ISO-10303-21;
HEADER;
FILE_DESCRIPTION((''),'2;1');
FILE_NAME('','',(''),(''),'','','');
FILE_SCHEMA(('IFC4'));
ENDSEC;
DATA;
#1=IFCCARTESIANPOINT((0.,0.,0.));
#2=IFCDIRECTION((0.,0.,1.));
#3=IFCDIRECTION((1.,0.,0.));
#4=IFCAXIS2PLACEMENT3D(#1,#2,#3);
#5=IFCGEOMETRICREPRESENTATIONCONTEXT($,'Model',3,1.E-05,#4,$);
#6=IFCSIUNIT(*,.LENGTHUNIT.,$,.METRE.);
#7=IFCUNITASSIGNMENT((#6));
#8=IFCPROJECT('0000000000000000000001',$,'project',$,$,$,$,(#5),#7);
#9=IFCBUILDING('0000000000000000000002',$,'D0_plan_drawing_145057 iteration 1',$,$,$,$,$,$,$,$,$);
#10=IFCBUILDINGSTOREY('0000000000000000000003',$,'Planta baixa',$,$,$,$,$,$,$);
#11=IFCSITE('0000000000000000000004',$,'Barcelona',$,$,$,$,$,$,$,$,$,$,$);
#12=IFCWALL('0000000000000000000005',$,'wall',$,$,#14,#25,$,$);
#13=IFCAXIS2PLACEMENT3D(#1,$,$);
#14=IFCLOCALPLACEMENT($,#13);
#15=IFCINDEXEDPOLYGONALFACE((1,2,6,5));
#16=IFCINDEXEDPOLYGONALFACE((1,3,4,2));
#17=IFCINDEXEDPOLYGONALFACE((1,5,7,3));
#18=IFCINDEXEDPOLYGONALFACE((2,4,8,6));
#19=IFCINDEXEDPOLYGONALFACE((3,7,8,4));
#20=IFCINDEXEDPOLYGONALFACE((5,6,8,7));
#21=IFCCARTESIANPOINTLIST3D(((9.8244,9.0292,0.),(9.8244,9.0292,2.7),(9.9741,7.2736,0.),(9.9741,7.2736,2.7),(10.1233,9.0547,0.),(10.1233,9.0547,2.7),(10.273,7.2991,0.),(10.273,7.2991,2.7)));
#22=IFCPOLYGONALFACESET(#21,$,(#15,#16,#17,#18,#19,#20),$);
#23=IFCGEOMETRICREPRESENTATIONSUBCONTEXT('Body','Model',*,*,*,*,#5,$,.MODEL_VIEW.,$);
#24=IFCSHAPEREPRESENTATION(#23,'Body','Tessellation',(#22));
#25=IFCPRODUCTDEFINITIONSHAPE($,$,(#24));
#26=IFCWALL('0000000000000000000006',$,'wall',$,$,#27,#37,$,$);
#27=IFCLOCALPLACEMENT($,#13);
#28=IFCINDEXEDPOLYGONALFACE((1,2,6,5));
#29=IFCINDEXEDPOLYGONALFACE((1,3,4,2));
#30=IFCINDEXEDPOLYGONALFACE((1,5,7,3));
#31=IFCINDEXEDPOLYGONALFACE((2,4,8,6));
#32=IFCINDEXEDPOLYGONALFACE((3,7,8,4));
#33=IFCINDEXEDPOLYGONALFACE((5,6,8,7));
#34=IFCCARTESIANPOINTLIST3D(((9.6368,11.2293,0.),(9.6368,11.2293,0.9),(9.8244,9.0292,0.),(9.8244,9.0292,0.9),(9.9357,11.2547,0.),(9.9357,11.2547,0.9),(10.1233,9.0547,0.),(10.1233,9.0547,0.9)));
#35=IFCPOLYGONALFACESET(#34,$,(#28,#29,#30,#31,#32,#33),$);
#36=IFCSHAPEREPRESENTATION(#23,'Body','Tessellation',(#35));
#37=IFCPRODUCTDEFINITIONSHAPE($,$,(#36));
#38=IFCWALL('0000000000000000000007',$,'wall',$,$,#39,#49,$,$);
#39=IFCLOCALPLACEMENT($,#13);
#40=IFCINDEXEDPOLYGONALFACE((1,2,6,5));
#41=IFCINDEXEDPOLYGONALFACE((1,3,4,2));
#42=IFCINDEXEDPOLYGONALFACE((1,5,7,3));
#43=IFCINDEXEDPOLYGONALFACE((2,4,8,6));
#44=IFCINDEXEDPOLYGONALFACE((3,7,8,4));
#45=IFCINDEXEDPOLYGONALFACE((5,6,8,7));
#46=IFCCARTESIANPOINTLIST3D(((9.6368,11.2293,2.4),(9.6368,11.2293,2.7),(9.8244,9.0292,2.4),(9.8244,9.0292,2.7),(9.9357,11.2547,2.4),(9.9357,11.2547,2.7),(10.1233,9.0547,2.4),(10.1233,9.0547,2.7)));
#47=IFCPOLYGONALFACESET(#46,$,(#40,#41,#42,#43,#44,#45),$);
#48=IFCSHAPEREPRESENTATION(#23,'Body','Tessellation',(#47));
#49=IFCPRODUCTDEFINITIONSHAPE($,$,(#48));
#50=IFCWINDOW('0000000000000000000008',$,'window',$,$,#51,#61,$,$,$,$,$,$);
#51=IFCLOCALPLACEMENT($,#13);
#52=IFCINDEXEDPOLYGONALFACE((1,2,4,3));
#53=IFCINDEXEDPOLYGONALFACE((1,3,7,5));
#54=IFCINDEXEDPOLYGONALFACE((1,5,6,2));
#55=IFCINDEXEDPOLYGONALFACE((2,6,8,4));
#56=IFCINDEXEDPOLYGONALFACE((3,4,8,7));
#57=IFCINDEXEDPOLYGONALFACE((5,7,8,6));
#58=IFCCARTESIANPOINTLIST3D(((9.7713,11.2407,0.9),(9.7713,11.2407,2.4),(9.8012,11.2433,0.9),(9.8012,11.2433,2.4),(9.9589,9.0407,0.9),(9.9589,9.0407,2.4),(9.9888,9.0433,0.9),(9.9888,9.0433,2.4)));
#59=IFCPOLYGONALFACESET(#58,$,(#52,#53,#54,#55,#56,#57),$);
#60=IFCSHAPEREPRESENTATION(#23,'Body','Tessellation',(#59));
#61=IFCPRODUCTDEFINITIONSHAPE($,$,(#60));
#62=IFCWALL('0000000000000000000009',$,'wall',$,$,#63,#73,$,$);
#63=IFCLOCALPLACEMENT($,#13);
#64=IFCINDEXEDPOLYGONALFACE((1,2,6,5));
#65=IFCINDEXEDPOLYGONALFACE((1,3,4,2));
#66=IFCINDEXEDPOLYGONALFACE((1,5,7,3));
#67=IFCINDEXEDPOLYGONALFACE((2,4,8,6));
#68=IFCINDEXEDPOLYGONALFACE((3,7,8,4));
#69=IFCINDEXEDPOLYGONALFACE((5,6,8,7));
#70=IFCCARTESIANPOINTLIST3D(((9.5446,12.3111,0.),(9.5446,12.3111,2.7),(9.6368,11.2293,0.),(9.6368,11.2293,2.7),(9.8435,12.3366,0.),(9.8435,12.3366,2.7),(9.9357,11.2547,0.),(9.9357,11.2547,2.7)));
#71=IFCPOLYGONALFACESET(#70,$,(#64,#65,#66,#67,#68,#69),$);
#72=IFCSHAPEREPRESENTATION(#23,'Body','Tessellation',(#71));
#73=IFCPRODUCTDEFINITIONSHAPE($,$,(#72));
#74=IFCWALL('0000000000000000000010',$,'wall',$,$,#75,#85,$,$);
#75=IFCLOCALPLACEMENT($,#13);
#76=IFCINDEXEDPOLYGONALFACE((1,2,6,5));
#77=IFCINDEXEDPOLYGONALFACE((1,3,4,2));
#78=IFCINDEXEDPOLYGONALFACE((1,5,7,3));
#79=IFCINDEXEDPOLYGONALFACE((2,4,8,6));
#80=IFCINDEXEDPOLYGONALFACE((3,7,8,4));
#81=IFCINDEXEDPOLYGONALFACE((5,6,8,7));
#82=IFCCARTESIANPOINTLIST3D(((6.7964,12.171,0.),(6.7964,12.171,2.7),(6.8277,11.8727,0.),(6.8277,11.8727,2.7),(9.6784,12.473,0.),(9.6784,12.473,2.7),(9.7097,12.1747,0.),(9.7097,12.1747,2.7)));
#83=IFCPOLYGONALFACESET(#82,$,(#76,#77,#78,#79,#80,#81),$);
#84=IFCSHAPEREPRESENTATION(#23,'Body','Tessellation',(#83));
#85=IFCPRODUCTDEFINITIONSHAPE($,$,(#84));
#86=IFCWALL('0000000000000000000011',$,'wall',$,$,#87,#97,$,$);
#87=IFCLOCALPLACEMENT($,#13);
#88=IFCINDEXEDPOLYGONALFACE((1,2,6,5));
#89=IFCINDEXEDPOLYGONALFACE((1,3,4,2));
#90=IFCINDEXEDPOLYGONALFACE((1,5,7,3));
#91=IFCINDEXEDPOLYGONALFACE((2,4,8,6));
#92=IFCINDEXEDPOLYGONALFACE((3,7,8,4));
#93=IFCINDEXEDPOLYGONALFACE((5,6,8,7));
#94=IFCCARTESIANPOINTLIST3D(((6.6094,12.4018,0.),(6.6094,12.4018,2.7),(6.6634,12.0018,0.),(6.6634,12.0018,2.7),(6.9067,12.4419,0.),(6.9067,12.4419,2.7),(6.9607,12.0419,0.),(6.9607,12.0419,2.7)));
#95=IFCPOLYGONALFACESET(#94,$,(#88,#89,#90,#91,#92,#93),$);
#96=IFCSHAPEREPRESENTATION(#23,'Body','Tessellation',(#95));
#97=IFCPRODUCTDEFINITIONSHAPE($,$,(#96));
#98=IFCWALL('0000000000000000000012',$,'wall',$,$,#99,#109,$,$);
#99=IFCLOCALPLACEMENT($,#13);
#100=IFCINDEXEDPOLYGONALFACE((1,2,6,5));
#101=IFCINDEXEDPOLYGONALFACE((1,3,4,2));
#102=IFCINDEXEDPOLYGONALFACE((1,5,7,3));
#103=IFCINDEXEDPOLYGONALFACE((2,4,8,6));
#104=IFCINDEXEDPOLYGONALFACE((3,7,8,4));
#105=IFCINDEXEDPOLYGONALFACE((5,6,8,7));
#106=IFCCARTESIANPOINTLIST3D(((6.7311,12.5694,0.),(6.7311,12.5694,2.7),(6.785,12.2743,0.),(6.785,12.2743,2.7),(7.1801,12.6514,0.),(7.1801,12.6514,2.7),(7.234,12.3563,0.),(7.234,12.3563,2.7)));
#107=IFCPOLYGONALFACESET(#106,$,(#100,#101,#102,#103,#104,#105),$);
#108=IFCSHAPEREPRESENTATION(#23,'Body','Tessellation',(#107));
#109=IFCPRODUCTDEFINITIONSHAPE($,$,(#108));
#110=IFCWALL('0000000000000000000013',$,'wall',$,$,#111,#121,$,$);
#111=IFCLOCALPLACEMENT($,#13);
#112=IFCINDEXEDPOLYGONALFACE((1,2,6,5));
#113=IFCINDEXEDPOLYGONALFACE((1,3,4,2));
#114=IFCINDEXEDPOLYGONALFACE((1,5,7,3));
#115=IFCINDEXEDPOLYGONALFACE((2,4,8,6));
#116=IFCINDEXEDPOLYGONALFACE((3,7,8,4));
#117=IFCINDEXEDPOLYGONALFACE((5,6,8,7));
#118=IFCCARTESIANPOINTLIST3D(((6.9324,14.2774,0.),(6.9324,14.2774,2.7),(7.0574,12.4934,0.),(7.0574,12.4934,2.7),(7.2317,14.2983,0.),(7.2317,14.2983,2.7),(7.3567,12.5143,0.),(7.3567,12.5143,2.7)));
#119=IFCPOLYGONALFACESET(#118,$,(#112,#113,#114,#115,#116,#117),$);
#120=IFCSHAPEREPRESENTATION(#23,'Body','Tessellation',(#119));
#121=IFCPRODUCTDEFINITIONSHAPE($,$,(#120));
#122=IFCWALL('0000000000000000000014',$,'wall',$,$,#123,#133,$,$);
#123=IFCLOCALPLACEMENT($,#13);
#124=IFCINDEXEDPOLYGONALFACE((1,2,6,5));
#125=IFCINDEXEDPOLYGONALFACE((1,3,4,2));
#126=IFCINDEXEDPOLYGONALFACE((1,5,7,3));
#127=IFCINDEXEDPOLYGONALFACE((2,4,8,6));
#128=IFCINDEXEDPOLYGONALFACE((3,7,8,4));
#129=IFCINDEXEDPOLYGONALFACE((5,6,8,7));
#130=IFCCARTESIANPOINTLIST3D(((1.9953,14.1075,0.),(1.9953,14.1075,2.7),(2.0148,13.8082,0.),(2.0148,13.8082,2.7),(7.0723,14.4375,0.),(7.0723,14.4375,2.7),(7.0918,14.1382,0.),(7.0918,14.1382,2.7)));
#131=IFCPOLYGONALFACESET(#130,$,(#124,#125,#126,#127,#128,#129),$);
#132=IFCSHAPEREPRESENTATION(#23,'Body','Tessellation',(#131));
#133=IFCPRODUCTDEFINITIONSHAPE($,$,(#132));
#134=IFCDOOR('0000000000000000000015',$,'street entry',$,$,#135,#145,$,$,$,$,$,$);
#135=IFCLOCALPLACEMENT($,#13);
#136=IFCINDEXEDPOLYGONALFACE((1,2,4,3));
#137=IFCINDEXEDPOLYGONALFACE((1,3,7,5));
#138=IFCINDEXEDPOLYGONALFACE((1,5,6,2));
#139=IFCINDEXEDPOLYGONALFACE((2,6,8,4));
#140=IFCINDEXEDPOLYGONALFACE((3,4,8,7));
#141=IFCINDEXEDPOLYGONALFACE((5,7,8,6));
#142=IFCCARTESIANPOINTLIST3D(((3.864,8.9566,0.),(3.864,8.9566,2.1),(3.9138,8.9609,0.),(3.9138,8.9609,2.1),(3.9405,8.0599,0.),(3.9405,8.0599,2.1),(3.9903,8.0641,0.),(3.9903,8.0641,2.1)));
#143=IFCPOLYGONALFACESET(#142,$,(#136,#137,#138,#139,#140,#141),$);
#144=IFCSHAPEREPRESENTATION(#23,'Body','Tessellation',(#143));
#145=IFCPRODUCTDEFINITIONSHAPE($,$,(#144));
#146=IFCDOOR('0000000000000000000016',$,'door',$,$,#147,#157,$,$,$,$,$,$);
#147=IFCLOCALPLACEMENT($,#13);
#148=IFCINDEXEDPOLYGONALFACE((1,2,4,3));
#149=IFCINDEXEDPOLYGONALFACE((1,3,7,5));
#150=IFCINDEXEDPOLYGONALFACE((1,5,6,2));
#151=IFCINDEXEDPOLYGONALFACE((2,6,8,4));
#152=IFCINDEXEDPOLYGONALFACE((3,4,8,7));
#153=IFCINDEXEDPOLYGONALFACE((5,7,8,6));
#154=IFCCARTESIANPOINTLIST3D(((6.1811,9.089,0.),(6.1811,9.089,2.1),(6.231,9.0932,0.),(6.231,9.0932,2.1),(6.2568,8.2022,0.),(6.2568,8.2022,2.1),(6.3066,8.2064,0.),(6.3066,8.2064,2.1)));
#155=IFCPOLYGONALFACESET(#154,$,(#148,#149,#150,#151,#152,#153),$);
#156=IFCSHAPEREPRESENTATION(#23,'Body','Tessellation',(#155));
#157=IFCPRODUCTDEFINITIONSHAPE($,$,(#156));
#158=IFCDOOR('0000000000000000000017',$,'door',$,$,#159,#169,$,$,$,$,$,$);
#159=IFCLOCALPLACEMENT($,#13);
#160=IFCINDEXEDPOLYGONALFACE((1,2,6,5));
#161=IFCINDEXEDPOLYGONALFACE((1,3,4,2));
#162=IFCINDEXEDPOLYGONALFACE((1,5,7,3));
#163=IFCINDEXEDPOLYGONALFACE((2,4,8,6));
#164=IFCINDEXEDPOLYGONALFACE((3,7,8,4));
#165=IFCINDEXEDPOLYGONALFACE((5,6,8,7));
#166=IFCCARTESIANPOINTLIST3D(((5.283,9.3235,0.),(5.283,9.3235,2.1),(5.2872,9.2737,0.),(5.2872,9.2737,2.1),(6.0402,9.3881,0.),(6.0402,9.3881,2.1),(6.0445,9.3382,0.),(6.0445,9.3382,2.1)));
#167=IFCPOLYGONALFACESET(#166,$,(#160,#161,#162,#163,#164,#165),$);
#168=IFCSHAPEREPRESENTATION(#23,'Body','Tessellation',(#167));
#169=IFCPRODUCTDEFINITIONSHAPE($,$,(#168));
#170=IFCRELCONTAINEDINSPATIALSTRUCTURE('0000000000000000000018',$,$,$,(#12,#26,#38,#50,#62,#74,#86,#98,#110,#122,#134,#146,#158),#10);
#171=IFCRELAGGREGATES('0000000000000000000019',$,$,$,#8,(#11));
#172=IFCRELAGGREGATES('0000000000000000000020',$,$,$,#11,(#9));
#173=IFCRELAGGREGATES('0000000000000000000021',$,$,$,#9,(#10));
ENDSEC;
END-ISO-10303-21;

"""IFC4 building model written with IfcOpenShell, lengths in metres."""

from ifc_helpers import new_model, si_unit, frame, origin, origin_with_axes, place, context, subcontext, project, spatial, polyline, outline, extrude, element, save


model = new_model("IFC4")

# Units and contexts
model_context = context("Model", 3, precision=1e-05, world=origin_with_axes())
body_context = subcontext(model_context, "Body", "Model", "MODEL_VIEW")
ifc_project = project(units=[si_unit("LENGTHUNIT", "METRE")], contexts=[model_context])

# Site, building, storey
site = spatial("IfcSite", under=ifc_project, Name="Barcelona")
building = spatial("IfcBuilding", under=site, Name="D0_plan_drawing_145057 iteration 1")
storey = spatial("IfcBuildingStorey", under=building, Name="Planta baixa")

# Walls
wall_1_placement = place(None, origin_with_axes())
element("IfcWall", 1, at=wall_1_placement, inside=storey, Name="wall", context=body_context, shape_type="SweptSolid", body=[
    extrude(outline(polyline([(9.9741, 7.2736), (9.8244, 9.0292), (10.1233, 9.0547), (10.273, 7.2991), (9.9741, 7.2736)])), origin(), (0.0, 0.0, 1.0), 2.7),
])
wall_2_placement = place(None, origin_with_axes())
element("IfcWall", 2, at=wall_2_placement, inside=storey, Name="wall", context=body_context, shape_type="SweptSolid", body=[
    extrude(outline(polyline([(9.8244, 9.0292), (9.6368, 11.2293), (9.9357, 11.2547), (10.1233, 9.0547), (9.8244, 9.0292)])), origin(), (0.0, 0.0, 1.0), 0.9),
])
wall_3_placement = place(None, origin_with_axes())
element("IfcWall", 3, at=wall_3_placement, inside=storey, Name="wall", context=body_context, shape_type="SweptSolid", body=[
    extrude(outline(polyline([(9.8244, 9.0292), (9.6368, 11.2293), (9.9357, 11.2547), (10.1233, 9.0547), (9.8244, 9.0292)])), frame((0.0, 0.0, 2.4)), (0.0, 0.0, 1.0), 0.3),
])

# Window
window_1_placement = place(None, origin_with_axes())
element("IfcWindow", 4, at=window_1_placement, inside=storey, Name="window", context=body_context, shape_type="SweptSolid", body=[
    extrude(outline(polyline([(9.9589, 9.0407), (9.7713, 11.2407), (9.8012, 11.2433), (9.9888, 9.0433), (9.9589, 9.0407)])), frame((0.0, 0.0, 0.9)), (0.0, 0.0, 1.0), 1.5),
])

# Walls
wall_4_placement = place(None, origin_with_axes())
element("IfcWall", 5, at=wall_4_placement, inside=storey, Name="wall", context=body_context, shape_type="SweptSolid", body=[
    extrude(outline(polyline([(9.6368, 11.2293), (9.5446, 12.3111), (9.8435, 12.3366), (9.9357, 11.2547), (9.6368, 11.2293)])), origin(), (0.0, 0.0, 1.0), 2.7),
])
wall_5_placement = place(None, origin_with_axes())
element("IfcWall", 6, at=wall_5_placement, inside=storey, Name="wall", context=body_context, shape_type="SweptSolid", body=[
    extrude(outline(polyline([(9.7097, 12.1747), (6.8277, 11.8727), (6.7964, 12.171), (9.6784, 12.473), (9.7097, 12.1747)])), origin(), (0.0, 0.0, 1.0), 2.7),
])
wall_6_placement = place(None, origin_with_axes())
element("IfcWall", 7, at=wall_6_placement, inside=storey, Name="wall", context=body_context, shape_type="SweptSolid", body=[
    extrude(outline(polyline([(6.6634, 12.0018), (6.6094, 12.4018), (6.9067, 12.4419), (6.9607, 12.0419), (6.6634, 12.0018)])), origin(), (0.0, 0.0, 1.0), 2.7),
])
wall_7_placement = place(None, origin_with_axes())
element("IfcWall", 8, at=wall_7_placement, inside=storey, Name="wall", context=body_context, shape_type="SweptSolid", body=[
    extrude(outline(polyline([(6.7311, 12.5694), (7.1801, 12.6514), (7.234, 12.3563), (6.785, 12.2743), (6.7311, 12.5694)])), origin(), (0.0, 0.0, 1.0), 2.7),
])
wall_8_placement = place(None, origin_with_axes())
element("IfcWall", 9, at=wall_8_placement, inside=storey, Name="wall", context=body_context, shape_type="SweptSolid", body=[
    extrude(outline(polyline([(7.0574, 12.4934), (6.9324, 14.2774), (7.2317, 14.2983), (7.3567, 12.5143), (7.0574, 12.4934)])), origin(), (0.0, 0.0, 1.0), 2.7),
])
wall_9_placement = place(None, origin_with_axes())
element("IfcWall", 10, at=wall_9_placement, inside=storey, Name="wall", context=body_context, shape_type="SweptSolid", body=[
    extrude(outline(polyline([(7.0918, 14.1382), (2.0148, 13.8082), (1.9953, 14.1075), (7.0723, 14.4375), (7.0918, 14.1382)])), origin(), (0.0, 0.0, 1.0), 2.7),
])

# Doors
door_1_placement = place(None, origin_with_axes())
element("IfcDoor", 11, at=door_1_placement, inside=storey, Name="street entry", context=body_context, shape_type="SweptSolid", body=[
    extrude(outline(polyline([(3.9405, 8.0599), (3.864, 8.9566), (3.9138, 8.9609), (3.9903, 8.0641), (3.9405, 8.0599)])), origin(), (0.0, 0.0, 1.0), 2.1),
])
door_2_placement = place(None, origin_with_axes())
element("IfcDoor", 12, at=door_2_placement, inside=storey, Name="door", context=body_context, shape_type="SweptSolid", body=[
    extrude(outline(polyline([(6.2568, 8.2022), (6.1811, 9.089), (6.231, 9.0932), (6.3066, 8.2064), (6.2568, 8.2022)])), origin(), (0.0, 0.0, 1.0), 2.1),
])
door_3_placement = place(None, origin_with_axes())
element("IfcDoor", 13, at=door_3_placement, inside=storey, Name="door", context=body_context, shape_type="SweptSolid", body=[
    extrude(outline(polyline([(6.0445, 9.3382), (5.2872, 9.2737), (5.283, 9.3235), (6.0402, 9.3881), (6.0445, 9.3382)])), origin(), (0.0, 0.0, 1.0), 2.1),
])

save(model, "model.ifc")
